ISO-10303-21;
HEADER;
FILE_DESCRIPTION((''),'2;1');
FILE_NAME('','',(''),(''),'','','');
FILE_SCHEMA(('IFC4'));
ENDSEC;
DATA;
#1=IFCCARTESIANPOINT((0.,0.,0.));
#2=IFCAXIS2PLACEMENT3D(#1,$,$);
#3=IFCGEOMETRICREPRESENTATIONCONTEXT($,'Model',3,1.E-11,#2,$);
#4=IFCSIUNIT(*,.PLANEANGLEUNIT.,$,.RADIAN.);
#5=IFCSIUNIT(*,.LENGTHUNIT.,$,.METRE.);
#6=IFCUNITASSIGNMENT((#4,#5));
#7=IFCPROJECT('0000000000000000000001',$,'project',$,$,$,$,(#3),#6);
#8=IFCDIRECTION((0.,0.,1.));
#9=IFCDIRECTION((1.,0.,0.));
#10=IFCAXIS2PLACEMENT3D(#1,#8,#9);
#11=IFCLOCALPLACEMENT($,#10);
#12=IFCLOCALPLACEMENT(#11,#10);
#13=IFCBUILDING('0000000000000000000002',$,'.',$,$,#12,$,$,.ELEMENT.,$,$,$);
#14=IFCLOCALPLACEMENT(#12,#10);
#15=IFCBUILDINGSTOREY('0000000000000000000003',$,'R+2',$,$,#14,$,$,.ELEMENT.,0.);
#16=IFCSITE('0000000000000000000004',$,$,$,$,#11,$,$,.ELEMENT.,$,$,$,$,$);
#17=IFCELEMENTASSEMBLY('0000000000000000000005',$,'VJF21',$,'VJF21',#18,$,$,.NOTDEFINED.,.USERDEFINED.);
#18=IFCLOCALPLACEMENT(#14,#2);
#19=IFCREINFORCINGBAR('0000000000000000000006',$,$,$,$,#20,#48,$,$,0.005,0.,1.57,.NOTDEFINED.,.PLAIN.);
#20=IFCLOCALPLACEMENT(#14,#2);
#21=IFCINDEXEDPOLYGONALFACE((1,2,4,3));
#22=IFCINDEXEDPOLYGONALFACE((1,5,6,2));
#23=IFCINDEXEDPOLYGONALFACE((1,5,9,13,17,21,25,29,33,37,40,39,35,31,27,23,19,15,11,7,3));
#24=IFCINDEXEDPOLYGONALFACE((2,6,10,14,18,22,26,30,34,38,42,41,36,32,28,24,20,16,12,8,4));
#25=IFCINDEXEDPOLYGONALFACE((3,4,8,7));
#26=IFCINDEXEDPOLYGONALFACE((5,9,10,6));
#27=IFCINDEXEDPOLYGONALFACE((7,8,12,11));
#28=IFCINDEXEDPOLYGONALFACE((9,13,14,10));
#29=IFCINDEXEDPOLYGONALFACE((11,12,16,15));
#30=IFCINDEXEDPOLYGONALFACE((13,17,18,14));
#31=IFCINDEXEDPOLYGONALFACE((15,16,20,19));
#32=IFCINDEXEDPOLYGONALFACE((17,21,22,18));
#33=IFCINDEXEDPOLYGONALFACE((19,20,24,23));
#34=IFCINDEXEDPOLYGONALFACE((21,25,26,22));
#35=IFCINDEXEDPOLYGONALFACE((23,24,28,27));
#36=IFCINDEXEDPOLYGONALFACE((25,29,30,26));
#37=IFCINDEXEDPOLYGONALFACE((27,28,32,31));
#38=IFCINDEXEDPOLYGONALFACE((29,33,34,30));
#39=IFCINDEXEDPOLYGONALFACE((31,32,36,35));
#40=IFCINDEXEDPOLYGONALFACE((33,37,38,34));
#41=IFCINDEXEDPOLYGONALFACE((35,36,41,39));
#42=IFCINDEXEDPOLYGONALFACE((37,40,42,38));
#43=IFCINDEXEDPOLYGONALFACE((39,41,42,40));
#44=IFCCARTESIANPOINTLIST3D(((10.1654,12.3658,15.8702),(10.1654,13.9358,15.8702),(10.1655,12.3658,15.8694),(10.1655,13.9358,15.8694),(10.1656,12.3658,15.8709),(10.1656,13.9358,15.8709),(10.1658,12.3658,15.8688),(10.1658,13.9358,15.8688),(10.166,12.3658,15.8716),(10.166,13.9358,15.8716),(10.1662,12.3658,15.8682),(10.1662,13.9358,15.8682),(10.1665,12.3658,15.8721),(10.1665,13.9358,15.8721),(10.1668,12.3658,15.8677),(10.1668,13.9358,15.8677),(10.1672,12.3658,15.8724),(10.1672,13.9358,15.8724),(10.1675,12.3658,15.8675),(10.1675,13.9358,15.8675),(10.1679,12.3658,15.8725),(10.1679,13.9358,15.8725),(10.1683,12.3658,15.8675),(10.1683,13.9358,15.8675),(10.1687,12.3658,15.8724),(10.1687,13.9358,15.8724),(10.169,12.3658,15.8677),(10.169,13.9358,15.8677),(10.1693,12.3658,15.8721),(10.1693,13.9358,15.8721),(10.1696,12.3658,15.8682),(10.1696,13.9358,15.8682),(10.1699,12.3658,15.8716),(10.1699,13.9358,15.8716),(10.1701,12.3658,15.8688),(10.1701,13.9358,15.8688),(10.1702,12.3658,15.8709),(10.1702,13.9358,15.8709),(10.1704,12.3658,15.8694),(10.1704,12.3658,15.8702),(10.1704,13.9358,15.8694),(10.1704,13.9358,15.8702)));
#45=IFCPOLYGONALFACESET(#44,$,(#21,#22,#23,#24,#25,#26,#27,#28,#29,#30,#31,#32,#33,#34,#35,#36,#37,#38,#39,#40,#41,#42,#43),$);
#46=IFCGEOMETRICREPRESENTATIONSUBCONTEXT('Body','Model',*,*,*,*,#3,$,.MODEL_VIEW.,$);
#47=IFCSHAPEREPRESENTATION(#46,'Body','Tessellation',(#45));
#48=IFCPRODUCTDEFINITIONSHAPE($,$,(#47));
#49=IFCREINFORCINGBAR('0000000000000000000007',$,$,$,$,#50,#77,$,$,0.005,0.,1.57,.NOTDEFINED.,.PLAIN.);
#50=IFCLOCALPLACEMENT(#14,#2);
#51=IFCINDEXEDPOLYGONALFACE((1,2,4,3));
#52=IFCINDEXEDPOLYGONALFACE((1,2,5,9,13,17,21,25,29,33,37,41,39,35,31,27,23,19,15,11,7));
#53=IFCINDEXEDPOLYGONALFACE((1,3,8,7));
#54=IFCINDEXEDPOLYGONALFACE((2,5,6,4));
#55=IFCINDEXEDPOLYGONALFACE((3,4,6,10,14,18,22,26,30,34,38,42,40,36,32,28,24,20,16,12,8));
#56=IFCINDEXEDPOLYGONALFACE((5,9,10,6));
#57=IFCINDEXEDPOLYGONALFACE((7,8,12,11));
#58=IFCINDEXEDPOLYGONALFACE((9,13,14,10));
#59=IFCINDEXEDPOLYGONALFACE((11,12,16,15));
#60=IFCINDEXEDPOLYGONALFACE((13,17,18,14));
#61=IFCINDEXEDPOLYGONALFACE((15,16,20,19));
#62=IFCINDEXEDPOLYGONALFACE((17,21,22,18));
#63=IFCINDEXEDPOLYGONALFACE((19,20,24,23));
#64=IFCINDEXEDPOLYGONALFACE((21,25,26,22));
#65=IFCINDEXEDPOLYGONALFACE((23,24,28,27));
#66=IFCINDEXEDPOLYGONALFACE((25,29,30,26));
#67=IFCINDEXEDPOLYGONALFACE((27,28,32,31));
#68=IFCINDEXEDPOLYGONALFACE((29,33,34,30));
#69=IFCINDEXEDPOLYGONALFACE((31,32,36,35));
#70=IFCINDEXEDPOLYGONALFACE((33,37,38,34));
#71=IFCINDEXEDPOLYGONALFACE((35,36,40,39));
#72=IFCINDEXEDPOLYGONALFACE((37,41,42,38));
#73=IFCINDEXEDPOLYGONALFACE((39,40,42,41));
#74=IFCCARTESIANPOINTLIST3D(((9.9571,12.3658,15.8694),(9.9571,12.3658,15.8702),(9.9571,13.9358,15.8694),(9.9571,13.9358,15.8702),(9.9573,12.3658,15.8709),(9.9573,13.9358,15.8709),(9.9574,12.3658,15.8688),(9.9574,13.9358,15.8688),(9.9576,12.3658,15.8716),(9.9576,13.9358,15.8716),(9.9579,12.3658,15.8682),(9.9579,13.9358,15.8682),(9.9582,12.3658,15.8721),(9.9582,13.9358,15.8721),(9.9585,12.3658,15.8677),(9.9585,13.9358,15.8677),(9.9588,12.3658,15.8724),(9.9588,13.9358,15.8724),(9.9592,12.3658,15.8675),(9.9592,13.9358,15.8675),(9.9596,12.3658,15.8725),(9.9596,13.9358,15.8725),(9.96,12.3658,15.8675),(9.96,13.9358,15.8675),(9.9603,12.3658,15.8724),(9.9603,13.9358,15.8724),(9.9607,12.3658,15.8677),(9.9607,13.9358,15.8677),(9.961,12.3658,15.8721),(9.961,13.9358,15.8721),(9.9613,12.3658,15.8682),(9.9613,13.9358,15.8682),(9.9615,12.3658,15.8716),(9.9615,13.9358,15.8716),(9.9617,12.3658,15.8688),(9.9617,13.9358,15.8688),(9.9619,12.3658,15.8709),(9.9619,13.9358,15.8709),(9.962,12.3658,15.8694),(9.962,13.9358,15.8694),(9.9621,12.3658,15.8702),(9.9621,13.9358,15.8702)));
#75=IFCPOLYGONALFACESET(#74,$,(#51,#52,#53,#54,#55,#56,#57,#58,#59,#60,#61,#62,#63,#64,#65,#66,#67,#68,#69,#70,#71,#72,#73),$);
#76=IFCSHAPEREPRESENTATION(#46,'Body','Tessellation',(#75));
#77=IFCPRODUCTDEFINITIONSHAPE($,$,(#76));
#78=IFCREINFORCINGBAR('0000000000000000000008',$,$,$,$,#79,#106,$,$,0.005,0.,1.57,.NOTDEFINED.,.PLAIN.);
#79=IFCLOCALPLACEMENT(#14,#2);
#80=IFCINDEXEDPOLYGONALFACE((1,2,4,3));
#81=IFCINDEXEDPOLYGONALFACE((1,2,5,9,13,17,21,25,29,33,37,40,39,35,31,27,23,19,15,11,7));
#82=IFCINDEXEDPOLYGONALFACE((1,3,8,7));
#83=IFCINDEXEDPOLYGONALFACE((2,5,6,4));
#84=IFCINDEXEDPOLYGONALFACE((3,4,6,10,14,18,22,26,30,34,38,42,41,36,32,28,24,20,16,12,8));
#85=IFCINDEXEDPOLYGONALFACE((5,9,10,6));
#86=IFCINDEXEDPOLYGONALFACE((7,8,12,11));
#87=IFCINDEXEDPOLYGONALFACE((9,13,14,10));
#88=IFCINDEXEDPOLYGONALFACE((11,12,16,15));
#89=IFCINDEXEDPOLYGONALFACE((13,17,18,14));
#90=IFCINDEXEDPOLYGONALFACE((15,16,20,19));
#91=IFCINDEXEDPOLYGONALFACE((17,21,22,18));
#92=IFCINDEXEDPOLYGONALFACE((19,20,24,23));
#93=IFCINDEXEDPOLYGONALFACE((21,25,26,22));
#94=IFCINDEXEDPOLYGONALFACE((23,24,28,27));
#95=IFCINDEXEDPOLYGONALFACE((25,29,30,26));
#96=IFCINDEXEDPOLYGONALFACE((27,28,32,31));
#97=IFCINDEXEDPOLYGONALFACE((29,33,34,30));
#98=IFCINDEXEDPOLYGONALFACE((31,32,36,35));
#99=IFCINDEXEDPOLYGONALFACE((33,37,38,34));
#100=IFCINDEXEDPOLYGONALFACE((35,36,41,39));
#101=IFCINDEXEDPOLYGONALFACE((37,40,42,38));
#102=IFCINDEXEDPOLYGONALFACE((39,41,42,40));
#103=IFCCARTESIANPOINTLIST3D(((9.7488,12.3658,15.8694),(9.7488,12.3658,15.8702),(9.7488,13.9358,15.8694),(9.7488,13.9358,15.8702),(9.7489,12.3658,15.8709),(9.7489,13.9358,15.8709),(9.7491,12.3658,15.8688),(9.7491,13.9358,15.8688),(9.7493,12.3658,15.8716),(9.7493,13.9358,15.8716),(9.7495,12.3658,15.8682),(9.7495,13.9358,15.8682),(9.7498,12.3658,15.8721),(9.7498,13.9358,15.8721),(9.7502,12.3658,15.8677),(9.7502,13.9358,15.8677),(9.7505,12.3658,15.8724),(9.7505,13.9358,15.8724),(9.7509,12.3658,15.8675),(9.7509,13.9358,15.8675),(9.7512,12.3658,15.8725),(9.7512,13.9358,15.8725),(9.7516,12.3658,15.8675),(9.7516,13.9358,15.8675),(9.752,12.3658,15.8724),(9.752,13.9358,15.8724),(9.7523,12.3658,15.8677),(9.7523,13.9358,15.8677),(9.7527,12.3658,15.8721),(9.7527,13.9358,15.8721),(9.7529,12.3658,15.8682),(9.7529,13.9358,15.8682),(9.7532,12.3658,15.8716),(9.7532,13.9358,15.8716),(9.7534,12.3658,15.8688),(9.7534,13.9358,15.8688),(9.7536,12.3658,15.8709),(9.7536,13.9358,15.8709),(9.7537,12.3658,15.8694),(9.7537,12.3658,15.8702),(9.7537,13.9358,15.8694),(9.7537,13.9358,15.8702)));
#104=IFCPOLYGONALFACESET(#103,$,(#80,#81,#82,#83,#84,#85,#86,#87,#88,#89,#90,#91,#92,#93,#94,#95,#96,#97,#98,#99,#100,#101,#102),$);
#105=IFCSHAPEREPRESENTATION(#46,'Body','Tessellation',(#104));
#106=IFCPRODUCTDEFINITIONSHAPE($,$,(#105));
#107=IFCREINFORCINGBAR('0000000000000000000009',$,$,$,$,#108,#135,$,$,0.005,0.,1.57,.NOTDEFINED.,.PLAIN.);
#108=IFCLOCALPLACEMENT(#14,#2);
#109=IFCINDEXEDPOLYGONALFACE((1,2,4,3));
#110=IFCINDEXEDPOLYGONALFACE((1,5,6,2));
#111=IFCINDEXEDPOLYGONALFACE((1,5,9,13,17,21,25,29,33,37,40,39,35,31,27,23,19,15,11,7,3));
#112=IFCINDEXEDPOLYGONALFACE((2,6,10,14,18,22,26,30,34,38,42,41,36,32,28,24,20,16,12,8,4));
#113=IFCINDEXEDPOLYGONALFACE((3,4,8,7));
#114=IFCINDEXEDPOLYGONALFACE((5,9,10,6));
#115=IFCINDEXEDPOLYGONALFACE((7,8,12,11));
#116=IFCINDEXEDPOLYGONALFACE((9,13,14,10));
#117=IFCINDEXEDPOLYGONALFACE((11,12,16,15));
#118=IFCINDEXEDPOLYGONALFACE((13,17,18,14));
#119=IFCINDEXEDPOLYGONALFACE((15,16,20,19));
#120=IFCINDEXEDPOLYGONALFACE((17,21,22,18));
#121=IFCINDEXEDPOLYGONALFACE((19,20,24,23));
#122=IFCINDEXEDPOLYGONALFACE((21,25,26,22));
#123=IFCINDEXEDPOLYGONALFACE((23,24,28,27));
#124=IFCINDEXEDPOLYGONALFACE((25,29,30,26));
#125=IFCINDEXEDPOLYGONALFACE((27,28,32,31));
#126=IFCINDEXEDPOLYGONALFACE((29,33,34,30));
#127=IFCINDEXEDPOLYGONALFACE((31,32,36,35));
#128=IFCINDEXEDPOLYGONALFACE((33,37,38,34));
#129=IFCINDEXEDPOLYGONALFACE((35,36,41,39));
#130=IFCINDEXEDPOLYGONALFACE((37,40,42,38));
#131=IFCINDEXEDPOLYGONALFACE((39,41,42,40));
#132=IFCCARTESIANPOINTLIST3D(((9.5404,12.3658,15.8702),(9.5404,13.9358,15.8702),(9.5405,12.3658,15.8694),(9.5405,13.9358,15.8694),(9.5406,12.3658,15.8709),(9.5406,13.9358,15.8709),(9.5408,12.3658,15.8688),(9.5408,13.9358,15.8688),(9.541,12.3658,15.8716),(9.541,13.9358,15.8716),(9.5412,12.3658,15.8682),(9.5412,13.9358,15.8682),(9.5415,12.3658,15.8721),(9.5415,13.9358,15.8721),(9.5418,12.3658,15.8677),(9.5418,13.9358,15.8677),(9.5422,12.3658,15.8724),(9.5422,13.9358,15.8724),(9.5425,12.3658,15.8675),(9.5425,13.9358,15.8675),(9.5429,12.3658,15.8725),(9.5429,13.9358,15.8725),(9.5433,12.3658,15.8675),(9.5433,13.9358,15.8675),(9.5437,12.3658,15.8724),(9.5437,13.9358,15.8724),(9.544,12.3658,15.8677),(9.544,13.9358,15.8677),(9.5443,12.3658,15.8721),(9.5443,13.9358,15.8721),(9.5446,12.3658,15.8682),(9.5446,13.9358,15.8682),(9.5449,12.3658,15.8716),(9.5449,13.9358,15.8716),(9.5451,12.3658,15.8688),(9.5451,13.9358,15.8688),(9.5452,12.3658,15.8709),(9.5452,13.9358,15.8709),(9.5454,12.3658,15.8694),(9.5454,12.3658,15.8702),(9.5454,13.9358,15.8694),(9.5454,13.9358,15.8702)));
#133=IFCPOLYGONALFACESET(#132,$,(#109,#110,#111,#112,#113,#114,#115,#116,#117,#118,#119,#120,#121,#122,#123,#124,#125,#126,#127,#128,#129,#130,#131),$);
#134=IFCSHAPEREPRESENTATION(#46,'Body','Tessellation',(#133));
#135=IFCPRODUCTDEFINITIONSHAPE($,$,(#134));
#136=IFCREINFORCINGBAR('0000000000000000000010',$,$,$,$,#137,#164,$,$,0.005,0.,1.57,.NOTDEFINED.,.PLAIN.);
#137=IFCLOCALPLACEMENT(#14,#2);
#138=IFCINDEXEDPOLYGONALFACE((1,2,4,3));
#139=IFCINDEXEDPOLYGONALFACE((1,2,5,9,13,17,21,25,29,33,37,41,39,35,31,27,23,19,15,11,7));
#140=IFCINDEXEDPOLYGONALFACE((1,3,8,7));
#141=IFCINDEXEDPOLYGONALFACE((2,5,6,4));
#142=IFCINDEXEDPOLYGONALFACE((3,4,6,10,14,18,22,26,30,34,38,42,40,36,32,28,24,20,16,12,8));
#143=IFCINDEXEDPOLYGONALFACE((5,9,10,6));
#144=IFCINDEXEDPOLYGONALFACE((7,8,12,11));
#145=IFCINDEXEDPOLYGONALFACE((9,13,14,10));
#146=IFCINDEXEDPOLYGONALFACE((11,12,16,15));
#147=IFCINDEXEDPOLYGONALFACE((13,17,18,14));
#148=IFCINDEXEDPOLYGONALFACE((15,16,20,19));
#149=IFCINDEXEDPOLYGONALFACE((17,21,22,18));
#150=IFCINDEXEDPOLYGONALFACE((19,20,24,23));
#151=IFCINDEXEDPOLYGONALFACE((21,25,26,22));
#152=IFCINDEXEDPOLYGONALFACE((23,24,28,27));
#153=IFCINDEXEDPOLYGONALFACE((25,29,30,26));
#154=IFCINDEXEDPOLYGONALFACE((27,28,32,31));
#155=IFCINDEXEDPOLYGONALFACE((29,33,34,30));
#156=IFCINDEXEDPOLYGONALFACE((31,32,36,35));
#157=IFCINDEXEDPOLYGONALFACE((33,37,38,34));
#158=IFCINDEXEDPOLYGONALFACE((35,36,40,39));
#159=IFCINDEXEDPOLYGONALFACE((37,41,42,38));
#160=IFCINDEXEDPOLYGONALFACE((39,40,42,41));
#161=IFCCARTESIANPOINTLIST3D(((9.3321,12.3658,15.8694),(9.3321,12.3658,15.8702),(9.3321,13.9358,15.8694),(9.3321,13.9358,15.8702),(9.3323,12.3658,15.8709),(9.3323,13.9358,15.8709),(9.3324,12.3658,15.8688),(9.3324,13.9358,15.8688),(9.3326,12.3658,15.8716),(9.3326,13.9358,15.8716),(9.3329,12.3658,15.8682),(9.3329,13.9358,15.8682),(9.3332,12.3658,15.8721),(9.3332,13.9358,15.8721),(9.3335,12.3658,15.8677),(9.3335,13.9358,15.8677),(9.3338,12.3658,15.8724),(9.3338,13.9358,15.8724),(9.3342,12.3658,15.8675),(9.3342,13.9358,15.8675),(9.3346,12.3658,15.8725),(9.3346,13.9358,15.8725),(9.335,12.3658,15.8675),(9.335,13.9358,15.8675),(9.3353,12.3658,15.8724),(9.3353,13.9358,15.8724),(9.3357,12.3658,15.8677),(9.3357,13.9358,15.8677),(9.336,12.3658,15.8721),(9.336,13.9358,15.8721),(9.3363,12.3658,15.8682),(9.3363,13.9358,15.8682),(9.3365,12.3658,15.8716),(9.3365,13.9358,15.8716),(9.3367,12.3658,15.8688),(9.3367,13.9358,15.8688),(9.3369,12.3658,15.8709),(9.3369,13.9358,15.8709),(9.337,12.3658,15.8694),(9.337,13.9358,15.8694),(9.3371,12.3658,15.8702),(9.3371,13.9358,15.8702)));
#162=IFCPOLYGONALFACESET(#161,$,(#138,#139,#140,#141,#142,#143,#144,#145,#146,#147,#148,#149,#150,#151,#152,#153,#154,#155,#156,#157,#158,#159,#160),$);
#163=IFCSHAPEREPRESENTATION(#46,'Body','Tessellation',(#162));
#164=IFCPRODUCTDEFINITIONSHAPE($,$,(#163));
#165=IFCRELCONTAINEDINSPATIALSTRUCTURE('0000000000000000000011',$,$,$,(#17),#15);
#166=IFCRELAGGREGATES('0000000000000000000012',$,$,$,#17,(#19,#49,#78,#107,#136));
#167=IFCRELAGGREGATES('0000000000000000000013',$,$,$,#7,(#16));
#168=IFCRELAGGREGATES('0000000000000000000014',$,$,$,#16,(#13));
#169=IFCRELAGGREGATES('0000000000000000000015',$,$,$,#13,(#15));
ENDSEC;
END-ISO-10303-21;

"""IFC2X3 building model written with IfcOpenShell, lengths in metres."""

from ifc_helpers import new_model, entity, si_unit, origin, origin_with_axes, place, context, subcontext, project, spatial, shape, element, aggregate, save


model = new_model("IFC2X3")

# Units and contexts
model_context = context("Model", 3, precision=1e-11, world=origin())
body_context = subcontext(model_context, "Body", "Model", "MODEL_VIEW")
ifc_project = project(units=[si_unit("PLANEANGLEUNIT", "RADIAN"), si_unit("LENGTHUNIT", "METRE")], contexts=[model_context])

# Site, building, storey
site_placement = place(None, origin_with_axes())
site = spatial("IfcSite", under=ifc_project, at=site_placement, CompositionType="ELEMENT")
building_placement = place(site_placement, origin_with_axes())
building = spatial("IfcBuilding", under=site, at=building_placement, Name=".", CompositionType="ELEMENT")
storey_placement = place(building_placement, origin_with_axes())
storey = spatial("IfcBuildingStorey", under=building, at=storey_placement, Name="R+2", CompositionType="ELEMENT", Elevation=0.0)

# Element assembly, reinforcing bars
assembly_1_placement = place(storey_placement, origin_with_axes())
assembly_1 = element("IfcElementAssembly", 1, at=assembly_1_placement, inside=storey, Name="VJF21", ObjectType="VJF21", AssemblyPlace="NOTDEFINED", PredefinedType="USERDEFINED")
reinforcing_bar_1_placement = place(assembly_1_placement, origin_with_axes())
reinforcing_bar_1 = element("IfcReinforcingBar", 2, at=reinforcing_bar_1_placement, BarLength=1.57, BarRole="NOTDEFINED", BarSurface="PLAIN", CrossSectionArea=0.0, NominalDiameter=0.005, shapes=[
    shape(body_context, "Body", "AdvancedSweptSolid", [entity("IfcSweptDiskSolid", entity("IfcPolyline", [entity("IfcCartesianPoint", [10.1679, 12.3658, 15.87]), entity("IfcCartesianPoint", [10.1679, 13.9358, 15.87])]), 0.0025, None, 0.0, 1.57)]),
    shape(body_context, "Body", "AdvancedSweptSolid", [entity("IfcSweptDiskSolid", entity("IfcPolyline", [entity("IfcCartesianPoint", [10.1679, 12.3658, 15.87]), entity("IfcCartesianPoint", [10.1679, 13.9358, 15.87])]), 0.0025, None, 0.0, 1.57)]),
])
reinforcing_bar_2_placement = place(assembly_1_placement, origin_with_axes())
reinforcing_bar_2 = element("IfcReinforcingBar", 3, at=reinforcing_bar_2_placement, BarLength=1.57, BarRole="NOTDEFINED", BarSurface="PLAIN", CrossSectionArea=0.0, NominalDiameter=0.005, shapes=[
    shape(body_context, "Body", "AdvancedSweptSolid", [entity("IfcSweptDiskSolid", entity("IfcPolyline", [entity("IfcCartesianPoint", [9.9596, 12.3658, 15.87]), entity("IfcCartesianPoint", [9.9596, 13.9358, 15.87])]), 0.0025, None, 0.0, 1.57)]),
    shape(body_context, "Body", "AdvancedSweptSolid", [entity("IfcSweptDiskSolid", entity("IfcPolyline", [entity("IfcCartesianPoint", [9.9596, 12.3658, 15.87]), entity("IfcCartesianPoint", [9.9596, 13.9358, 15.87])]), 0.0025, None, 0.0, 1.57)]),
])
reinforcing_bar_3_placement = place(assembly_1_placement, origin_with_axes())
reinforcing_bar_3 = element("IfcReinforcingBar", 4, at=reinforcing_bar_3_placement, BarLength=1.57, BarRole="NOTDEFINED", BarSurface="PLAIN", CrossSectionArea=0.0, NominalDiameter=0.005, shapes=[
    shape(body_context, "Body", "AdvancedSweptSolid", [entity("IfcSweptDiskSolid", entity("IfcPolyline", [entity("IfcCartesianPoint", [9.7512, 12.3658, 15.87]), entity("IfcCartesianPoint", [9.7512, 13.9358, 15.87])]), 0.0025, None, 0.0, 1.57)]),
    shape(body_context, "Body", "AdvancedSweptSolid", [entity("IfcSweptDiskSolid", entity("IfcPolyline", [entity("IfcCartesianPoint", [9.7512, 12.3658, 15.87]), entity("IfcCartesianPoint", [9.7512, 13.9358, 15.87])]), 0.0025, None, 0.0, 1.57)]),
])
reinforcing_bar_4_placement = place(assembly_1_placement, origin_with_axes())
reinforcing_bar_4 = element("IfcReinforcingBar", 5, at=reinforcing_bar_4_placement, BarLength=1.57, BarRole="NOTDEFINED", BarSurface="PLAIN", CrossSectionArea=0.0, NominalDiameter=0.005, shapes=[
    shape(body_context, "Body", "AdvancedSweptSolid", [entity("IfcSweptDiskSolid", entity("IfcPolyline", [entity("IfcCartesianPoint", [9.5429, 12.3658, 15.87]), entity("IfcCartesianPoint", [9.5429, 13.9358, 15.87])]), 0.0025, None, 0.0, 1.57)]),
    shape(body_context, "Body", "AdvancedSweptSolid", [entity("IfcSweptDiskSolid", entity("IfcPolyline", [entity("IfcCartesianPoint", [9.5429, 12.3658, 15.87]), entity("IfcCartesianPoint", [9.5429, 13.9358, 15.87])]), 0.0025, None, 0.0, 1.57)]),
])
reinforcing_bar_5_placement = place(assembly_1_placement, origin_with_axes())
reinforcing_bar_5 = element("IfcReinforcingBar", 6, at=reinforcing_bar_5_placement, BarLength=1.57, BarRole="NOTDEFINED", BarSurface="PLAIN", CrossSectionArea=0.0, NominalDiameter=0.005, shapes=[
    shape(body_context, "Body", "AdvancedSweptSolid", [entity("IfcSweptDiskSolid", entity("IfcPolyline", [entity("IfcCartesianPoint", [9.3346, 12.3658, 15.87]), entity("IfcCartesianPoint", [9.3346, 13.9358, 15.87])]), 0.0025, None, 0.0, 1.57)]),
    shape(body_context, "Body", "AdvancedSweptSolid", [entity("IfcSweptDiskSolid", entity("IfcPolyline", [entity("IfcCartesianPoint", [9.3346, 12.3658, 15.87]), entity("IfcCartesianPoint", [9.3346, 13.9358, 15.87])]), 0.0025, None, 0.0, 1.57)]),
])
aggregate(assembly_1, [reinforcing_bar_1, reinforcing_bar_2, reinforcing_bar_3, reinforcing_bar_4, reinforcing_bar_5])

save(model, "model.ifc")
